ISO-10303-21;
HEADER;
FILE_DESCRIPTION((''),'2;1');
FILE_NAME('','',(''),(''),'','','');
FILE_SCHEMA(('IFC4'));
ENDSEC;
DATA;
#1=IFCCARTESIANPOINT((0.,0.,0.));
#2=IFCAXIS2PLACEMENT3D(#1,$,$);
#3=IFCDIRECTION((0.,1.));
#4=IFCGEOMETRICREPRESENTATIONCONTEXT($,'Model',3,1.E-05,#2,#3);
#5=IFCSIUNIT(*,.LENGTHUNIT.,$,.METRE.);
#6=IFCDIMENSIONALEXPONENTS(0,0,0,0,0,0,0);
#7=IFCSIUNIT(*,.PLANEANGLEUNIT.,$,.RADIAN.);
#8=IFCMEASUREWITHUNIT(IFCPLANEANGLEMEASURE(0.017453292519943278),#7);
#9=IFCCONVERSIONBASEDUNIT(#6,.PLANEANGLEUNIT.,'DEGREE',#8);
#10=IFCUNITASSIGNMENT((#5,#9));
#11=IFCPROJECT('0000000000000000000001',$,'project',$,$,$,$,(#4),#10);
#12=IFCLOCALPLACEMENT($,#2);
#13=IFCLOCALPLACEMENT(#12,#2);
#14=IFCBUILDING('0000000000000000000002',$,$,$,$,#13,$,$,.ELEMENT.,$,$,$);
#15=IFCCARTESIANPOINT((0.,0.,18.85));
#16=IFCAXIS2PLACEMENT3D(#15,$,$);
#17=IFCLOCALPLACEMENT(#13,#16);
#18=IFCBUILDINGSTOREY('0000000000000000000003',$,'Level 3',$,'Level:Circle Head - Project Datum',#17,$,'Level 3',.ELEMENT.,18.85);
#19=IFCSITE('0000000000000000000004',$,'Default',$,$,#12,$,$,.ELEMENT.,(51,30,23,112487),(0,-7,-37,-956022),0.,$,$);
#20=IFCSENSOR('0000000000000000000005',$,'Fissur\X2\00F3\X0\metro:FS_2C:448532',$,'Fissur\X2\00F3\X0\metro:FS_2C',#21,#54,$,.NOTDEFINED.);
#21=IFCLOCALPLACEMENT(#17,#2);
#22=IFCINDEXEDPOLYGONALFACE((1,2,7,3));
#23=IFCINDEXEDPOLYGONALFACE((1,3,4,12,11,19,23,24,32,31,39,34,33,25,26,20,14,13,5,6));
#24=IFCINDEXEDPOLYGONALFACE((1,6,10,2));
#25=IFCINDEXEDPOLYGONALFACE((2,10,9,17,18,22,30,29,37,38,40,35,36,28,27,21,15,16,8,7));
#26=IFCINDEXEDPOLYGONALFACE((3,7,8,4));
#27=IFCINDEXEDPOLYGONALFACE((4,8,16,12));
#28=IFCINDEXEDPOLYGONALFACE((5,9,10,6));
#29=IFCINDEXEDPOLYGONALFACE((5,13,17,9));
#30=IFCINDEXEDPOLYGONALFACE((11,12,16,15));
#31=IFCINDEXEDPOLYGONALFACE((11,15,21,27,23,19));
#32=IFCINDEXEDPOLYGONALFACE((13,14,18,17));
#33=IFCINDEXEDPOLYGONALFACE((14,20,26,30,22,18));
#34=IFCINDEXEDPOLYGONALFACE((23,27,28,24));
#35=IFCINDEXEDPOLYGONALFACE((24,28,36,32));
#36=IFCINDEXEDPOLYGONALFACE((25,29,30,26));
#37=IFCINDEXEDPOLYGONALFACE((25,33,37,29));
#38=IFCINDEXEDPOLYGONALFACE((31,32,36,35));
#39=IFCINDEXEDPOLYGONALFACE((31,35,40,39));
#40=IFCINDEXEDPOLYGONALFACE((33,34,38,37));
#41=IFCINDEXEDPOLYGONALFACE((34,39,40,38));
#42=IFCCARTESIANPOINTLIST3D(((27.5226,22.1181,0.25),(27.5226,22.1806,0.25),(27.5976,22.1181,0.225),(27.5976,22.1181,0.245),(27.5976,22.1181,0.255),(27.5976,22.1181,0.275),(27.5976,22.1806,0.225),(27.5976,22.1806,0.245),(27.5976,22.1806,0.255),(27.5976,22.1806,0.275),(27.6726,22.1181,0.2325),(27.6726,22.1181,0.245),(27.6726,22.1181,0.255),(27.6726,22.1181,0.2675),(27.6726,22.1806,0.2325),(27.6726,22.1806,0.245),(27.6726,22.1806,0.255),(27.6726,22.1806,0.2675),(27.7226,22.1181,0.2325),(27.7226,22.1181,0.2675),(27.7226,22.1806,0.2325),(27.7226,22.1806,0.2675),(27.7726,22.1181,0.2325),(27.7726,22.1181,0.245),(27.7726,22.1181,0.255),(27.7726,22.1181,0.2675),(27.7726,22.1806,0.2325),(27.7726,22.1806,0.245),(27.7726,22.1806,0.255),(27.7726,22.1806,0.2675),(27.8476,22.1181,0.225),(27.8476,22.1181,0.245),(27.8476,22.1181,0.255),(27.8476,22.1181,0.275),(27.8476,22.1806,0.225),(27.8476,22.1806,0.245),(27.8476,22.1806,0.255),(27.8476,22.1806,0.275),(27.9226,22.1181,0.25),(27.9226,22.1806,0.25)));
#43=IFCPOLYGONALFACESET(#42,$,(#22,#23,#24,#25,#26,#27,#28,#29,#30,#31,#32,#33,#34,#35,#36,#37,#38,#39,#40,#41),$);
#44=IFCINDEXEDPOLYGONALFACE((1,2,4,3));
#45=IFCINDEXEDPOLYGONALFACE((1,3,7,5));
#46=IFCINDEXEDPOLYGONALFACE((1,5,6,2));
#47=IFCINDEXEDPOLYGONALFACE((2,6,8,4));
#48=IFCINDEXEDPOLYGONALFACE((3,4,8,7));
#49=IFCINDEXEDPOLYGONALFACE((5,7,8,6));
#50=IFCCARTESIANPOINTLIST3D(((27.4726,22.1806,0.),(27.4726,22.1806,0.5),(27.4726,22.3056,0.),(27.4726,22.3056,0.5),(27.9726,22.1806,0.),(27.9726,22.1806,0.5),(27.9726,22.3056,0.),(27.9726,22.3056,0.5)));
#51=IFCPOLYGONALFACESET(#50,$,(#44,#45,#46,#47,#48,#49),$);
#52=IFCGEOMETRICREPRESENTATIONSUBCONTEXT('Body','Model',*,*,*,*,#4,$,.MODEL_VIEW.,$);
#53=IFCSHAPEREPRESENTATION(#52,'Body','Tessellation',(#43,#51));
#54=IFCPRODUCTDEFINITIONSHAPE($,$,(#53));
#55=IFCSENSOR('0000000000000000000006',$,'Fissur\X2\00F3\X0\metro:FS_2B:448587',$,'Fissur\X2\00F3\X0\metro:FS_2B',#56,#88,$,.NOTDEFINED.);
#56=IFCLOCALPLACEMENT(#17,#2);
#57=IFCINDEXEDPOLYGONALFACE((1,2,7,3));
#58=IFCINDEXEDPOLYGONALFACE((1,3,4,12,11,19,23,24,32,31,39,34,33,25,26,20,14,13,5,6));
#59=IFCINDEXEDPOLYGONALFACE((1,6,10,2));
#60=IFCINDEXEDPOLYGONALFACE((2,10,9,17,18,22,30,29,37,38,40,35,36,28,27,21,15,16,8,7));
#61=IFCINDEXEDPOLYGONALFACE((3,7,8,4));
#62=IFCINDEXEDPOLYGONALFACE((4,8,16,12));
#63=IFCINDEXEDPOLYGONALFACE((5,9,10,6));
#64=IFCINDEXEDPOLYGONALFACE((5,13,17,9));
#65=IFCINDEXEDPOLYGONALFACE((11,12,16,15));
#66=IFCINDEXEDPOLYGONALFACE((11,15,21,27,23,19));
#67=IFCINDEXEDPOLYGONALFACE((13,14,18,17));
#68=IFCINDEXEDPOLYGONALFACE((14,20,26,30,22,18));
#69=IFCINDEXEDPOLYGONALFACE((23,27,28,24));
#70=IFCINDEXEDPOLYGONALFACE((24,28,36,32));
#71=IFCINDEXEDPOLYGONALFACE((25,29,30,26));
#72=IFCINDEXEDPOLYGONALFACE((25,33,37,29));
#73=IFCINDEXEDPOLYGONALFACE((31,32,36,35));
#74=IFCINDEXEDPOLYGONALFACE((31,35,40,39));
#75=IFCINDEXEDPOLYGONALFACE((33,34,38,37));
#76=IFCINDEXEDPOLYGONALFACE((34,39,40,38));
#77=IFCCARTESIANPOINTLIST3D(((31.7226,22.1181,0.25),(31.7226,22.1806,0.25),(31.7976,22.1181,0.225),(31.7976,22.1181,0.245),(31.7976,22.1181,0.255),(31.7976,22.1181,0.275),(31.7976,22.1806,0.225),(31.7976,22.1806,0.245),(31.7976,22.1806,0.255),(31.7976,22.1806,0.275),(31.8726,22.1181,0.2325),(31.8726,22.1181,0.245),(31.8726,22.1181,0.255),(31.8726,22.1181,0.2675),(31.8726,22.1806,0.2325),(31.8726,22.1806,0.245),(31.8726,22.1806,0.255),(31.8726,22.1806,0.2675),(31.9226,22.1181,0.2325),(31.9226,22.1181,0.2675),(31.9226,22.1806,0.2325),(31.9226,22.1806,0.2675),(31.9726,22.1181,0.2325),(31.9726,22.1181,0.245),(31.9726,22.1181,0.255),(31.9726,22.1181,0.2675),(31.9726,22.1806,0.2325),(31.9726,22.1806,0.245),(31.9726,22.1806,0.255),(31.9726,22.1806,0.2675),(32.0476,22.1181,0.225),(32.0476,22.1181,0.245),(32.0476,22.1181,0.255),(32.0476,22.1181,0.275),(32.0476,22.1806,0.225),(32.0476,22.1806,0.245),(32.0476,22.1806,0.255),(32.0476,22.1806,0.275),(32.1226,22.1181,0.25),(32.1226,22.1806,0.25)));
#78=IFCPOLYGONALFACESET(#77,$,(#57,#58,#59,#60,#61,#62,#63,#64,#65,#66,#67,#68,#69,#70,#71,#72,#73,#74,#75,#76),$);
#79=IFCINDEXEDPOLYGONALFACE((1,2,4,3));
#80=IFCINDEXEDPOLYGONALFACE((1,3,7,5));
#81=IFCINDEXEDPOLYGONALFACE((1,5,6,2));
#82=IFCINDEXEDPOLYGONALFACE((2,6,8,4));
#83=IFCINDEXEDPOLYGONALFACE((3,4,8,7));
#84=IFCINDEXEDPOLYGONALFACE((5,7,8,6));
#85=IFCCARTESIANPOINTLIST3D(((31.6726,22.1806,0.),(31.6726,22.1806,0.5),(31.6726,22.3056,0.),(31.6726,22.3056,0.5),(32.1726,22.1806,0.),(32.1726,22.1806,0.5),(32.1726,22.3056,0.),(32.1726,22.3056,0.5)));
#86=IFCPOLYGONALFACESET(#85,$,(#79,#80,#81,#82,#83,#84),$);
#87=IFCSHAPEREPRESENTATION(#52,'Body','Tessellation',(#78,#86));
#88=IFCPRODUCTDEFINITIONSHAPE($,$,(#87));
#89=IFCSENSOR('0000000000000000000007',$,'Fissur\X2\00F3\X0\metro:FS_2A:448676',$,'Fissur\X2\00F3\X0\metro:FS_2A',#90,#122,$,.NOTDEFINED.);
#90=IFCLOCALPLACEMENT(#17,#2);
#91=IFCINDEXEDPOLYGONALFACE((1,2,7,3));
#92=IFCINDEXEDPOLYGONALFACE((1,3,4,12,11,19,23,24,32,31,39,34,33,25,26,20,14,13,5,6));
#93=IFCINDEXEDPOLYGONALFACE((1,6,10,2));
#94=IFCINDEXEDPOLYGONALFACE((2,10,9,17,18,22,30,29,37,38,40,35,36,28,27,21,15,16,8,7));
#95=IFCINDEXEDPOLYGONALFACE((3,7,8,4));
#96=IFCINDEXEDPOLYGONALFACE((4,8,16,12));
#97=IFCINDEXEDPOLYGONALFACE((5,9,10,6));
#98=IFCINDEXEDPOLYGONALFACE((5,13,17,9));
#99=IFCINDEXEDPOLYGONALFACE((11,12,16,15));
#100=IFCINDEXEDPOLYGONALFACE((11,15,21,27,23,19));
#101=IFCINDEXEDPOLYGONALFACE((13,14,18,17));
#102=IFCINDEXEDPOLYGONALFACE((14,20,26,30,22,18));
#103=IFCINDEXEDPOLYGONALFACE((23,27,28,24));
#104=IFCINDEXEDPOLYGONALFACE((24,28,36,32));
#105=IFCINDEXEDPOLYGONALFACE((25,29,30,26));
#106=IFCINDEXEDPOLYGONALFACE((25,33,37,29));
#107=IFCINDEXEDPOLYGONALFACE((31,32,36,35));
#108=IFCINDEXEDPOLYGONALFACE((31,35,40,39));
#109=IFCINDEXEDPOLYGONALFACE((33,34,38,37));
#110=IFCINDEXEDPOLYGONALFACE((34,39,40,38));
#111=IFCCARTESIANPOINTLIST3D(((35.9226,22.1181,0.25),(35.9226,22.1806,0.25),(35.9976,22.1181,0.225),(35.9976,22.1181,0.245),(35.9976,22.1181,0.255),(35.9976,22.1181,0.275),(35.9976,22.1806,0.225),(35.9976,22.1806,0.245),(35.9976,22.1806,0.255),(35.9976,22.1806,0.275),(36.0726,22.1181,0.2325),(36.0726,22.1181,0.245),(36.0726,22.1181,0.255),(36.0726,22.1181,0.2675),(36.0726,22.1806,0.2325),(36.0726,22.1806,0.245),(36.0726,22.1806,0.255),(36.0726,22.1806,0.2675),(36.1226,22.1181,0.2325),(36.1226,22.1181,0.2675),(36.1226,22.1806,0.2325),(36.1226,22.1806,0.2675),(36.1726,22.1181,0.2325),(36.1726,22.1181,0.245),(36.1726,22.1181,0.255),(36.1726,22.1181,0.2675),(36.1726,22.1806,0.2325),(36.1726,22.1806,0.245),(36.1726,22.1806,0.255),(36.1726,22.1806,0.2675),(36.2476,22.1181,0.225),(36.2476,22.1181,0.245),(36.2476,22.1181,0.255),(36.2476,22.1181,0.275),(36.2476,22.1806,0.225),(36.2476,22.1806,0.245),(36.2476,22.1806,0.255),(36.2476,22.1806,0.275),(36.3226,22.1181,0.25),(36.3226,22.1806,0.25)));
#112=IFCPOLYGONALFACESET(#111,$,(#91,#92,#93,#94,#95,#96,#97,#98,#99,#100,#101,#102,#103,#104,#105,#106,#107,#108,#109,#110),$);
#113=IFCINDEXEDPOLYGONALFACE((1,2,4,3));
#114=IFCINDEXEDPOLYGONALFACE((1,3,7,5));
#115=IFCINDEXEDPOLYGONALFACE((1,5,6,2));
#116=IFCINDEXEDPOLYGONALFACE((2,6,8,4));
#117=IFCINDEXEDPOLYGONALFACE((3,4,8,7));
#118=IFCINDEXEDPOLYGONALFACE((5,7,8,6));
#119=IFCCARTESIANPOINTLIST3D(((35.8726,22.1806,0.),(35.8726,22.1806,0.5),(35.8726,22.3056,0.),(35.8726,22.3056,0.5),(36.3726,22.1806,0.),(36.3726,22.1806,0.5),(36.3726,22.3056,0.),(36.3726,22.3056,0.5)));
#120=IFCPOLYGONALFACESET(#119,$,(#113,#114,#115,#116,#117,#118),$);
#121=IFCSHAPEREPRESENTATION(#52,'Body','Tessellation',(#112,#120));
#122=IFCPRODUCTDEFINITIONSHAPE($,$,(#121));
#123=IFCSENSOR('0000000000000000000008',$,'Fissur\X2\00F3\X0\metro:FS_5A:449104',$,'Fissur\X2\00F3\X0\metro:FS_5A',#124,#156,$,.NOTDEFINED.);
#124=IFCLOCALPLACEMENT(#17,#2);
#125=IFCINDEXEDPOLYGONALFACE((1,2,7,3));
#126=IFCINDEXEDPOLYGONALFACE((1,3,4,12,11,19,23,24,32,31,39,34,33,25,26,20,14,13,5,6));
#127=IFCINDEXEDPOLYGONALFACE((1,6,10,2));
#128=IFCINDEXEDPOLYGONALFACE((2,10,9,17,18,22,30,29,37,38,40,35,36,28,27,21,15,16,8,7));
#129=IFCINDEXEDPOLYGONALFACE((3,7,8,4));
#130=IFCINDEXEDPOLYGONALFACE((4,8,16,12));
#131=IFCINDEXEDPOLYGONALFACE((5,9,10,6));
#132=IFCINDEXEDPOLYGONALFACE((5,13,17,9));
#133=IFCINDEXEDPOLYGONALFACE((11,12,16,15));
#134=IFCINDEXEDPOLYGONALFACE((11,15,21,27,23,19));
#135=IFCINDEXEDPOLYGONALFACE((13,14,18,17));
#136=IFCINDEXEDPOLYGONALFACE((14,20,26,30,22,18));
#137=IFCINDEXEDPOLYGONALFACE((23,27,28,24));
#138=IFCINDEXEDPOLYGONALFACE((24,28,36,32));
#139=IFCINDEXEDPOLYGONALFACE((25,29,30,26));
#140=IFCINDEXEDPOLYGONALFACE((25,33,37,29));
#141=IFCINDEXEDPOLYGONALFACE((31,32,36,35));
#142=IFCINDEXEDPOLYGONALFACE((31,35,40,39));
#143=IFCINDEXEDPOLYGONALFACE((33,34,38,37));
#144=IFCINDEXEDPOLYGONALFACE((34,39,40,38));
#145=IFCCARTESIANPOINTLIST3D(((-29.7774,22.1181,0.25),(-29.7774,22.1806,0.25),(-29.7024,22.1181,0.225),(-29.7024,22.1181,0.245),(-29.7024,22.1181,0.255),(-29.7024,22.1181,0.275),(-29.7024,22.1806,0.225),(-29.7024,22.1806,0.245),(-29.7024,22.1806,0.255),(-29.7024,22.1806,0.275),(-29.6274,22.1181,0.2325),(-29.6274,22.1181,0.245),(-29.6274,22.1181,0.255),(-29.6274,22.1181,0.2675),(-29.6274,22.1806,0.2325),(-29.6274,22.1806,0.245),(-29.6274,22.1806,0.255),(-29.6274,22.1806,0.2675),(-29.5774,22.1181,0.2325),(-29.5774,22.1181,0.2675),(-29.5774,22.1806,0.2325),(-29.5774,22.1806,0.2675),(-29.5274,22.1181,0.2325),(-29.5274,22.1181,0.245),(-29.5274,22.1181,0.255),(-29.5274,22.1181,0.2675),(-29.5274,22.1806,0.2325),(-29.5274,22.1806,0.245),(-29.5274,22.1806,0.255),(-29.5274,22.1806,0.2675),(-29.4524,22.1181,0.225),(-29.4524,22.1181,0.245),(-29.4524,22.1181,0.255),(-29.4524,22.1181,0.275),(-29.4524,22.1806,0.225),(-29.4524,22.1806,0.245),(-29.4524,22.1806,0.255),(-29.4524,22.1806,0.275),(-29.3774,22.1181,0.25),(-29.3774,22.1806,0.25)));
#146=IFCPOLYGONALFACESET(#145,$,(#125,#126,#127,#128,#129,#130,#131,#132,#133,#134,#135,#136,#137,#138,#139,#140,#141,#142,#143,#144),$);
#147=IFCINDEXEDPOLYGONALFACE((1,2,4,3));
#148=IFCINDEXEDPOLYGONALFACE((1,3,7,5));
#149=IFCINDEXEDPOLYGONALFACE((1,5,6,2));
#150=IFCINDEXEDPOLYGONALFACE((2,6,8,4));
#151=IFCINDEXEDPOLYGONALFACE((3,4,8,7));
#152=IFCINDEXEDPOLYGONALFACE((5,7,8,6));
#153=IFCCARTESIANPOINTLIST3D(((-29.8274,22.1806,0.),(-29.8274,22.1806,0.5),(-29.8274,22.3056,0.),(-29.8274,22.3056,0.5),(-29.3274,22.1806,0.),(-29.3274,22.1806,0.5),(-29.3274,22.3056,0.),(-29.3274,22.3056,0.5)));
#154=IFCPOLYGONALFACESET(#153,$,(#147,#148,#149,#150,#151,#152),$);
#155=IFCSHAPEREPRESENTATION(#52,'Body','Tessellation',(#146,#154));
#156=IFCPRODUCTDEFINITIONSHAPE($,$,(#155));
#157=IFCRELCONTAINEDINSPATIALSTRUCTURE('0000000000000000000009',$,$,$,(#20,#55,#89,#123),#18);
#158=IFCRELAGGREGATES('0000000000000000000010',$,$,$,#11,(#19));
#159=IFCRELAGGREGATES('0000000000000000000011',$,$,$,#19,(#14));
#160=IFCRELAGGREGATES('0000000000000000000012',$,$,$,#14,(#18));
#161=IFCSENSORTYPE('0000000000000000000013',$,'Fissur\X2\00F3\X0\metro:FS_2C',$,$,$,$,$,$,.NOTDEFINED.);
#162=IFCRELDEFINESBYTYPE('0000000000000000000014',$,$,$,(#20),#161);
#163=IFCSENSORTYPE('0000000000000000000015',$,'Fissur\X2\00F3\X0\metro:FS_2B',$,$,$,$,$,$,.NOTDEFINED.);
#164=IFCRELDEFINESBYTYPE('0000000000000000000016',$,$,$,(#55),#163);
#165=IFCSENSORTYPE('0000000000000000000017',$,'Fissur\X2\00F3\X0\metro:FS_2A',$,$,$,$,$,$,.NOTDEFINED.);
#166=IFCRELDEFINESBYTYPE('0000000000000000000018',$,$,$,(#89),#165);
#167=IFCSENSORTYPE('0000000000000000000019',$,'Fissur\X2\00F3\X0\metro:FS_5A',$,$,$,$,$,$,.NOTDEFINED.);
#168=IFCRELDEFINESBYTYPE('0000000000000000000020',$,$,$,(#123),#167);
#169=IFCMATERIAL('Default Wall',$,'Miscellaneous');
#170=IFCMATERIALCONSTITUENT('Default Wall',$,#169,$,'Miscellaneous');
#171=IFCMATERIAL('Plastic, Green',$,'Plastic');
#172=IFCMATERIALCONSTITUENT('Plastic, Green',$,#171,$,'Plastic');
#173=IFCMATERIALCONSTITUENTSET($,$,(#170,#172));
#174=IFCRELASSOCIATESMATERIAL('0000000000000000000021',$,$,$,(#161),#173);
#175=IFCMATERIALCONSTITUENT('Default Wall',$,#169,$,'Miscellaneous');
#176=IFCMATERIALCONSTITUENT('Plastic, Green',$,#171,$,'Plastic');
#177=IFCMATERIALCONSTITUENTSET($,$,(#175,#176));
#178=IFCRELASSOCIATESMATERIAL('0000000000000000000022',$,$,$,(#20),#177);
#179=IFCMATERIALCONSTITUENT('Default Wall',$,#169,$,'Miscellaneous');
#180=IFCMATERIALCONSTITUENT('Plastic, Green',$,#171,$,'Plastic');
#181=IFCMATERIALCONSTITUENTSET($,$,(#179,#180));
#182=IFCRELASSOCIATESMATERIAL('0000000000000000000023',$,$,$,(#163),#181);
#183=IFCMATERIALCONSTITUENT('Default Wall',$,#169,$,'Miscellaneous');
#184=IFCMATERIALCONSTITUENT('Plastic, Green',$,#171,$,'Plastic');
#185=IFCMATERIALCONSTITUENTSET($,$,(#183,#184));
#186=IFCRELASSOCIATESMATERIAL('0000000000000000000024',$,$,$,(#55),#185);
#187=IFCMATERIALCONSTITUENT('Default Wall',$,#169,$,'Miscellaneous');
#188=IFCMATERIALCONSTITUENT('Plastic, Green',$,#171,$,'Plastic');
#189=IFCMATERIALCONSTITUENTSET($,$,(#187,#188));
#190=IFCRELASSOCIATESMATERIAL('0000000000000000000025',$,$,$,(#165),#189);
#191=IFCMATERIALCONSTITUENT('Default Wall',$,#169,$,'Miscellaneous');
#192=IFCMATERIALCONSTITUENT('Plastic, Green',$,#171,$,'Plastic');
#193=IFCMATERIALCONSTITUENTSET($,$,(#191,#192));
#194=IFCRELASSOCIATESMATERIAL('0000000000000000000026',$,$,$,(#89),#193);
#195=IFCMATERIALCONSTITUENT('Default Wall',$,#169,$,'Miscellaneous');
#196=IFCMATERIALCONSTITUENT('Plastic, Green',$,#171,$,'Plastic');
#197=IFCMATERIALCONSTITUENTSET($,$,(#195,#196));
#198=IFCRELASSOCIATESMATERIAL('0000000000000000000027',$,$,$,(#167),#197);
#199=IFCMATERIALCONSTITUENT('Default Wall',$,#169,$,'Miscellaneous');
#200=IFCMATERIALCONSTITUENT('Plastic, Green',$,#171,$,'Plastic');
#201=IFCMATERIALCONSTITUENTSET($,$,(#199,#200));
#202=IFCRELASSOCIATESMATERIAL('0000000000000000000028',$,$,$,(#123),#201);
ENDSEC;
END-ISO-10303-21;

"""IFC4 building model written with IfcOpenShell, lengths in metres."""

from ifc_helpers import new_model, entity, si_unit, converted_unit, direction, frame, origin, place, context, subcontext, project, spatial, indexed_curve, outline, extrude, source, transform, mapped, material, constituent, constituent_set, type_object, type_shapes, element, save


model = new_model("IFC4")

# Units and contexts
model_context = context("Model", 3, precision=1e-05, world=origin(), true_north=direction((0.0, 1.0)))
body_context = subcontext(model_context, "Body", "Model", "MODEL_VIEW")
ifc_project = project(units=[si_unit("LENGTHUNIT", "METRE"), converted_unit("PLANEANGLEUNIT", "DEGREE", entity("IfcPlaneAngleMeasure", 0.017453292519943278), si_unit("PLANEANGLEUNIT", "RADIAN"), dimensions=[0, 0, 0, 0, 0, 0, 0])], contexts=[model_context])

# Site, building, storey
site_placement = place(None, origin())
site = spatial("IfcSite", under=ifc_project, at=site_placement, Name="Default", CompositionType="ELEMENT", RefLatitude=(51, 30, 23, 112487), RefLongitude=(0, -7, -37, -956022), RefElevation=0.0)
building_placement = place(site_placement, origin())
building = spatial("IfcBuilding", under=site, at=building_placement, CompositionType="ELEMENT")
storey_placement = place(building_placement, frame((0.0, 0.0, 18.85)))
storey = spatial("IfcBuildingStorey", under=building, at=storey_placement, Name="Level 3", ObjectType="Level:Circle Head - Project Datum", LongName="Level 3", CompositionType="ELEMENT", Elevation=18.85)

# Sensors
ifc_material_1 = material(Name="Default Wall", Category="Miscellaneous")
ifc_constituent_1 = constituent(ifc_material_1, Name="Default Wall", Category="Miscellaneous")
ifc_material_2 = material(Name="Plastic, Green", Category="Plastic")
ifc_constituent_2 = constituent(ifc_material_2, Name="Plastic, Green", Category="Plastic")
ifc_constituent_set_1 = constituent_set(constituents=[ifc_constituent_1, ifc_constituent_2])
ifc_constituent_3 = constituent(ifc_material_1, Name="Default Wall", Category="Miscellaneous")
ifc_constituent_4 = constituent(ifc_material_2, Name="Plastic, Green", Category="Plastic")
ifc_constituent_set_2 = constituent_set(constituents=[ifc_constituent_3, ifc_constituent_4])
sensor_type_1 = type_object("IfcSensorType", Name="Fissurómetro:FS_2C", PredefinedType="NOTDEFINED", material=ifc_constituent_set_2)
shared_shape_1 = source(origin(), body_context, "Body", "SweptSolid", [
    extrude(outline(indexed_curve([(-0.025, -0.125), (0.0, -0.2), (0.025, -0.125), (0.005, -0.125), (0.005, -0.05), (0.0175, -0.05), (0.0175, 0.0), (0.0175, 0.05), (0.005, 0.05), (0.005, 0.125), (0.025, 0.125), (0.0, 0.2), (-0.025, 0.125), (-0.005, 0.125), (-0.005, 0.05), (-0.0175, 0.05), (-0.0175, 0.0), (-0.0175, -0.05), (-0.005, -0.05), (-0.005, -0.125), (-0.025, -0.125)], self_intersect=False)), frame((0.0, -0.125, 0.25), z_axis=(0.0, -1.0, 0.0), x_axis=(0.0, 0.0, -1.0)), (0.0, 0.0, -1.0), 0.0625),
    extrude(outline(indexed_curve([(-0.25, -0.0625), (0.25, -0.0625), (0.25, 0.0625), (-0.25, 0.0625), (-0.25, -0.0625)], self_intersect=False)), frame((0.0, 0.0, 0.0), z_axis=(0.0, 0.0, 1.0), x_axis=(-1.0, 0.0, 0.0)), (0.0, 0.0, 1.0), 0.5),
])
type_shapes(sensor_type_1, [shared_shape_1])
sensor_1_placement = place(storey_placement, frame((27.7226, 22.2431, 0.0)))
element("IfcSensor", 1, at=sensor_1_placement, inside=storey, type_object=sensor_type_1, material=ifc_constituent_set_1, Name="Fissurómetro:FS_2C:448532", ObjectType="Fissurómetro:FS_2C", PredefinedType="NOTDEFINED", context=body_context, shape_type="MappedRepresentation", body=[
    mapped(shared_shape_1, transform((0.0, 0.0, 0.0), scale=1.0)),
])
ifc_constituent_5 = constituent(ifc_material_1, Name="Default Wall", Category="Miscellaneous")
ifc_constituent_6 = constituent(ifc_material_2, Name="Plastic, Green", Category="Plastic")
ifc_constituent_set_3 = constituent_set(constituents=[ifc_constituent_5, ifc_constituent_6])
ifc_constituent_7 = constituent(ifc_material_1, Name="Default Wall", Category="Miscellaneous")
ifc_constituent_8 = constituent(ifc_material_2, Name="Plastic, Green", Category="Plastic")
ifc_constituent_set_4 = constituent_set(constituents=[ifc_constituent_7, ifc_constituent_8])
sensor_type_2 = type_object("IfcSensorType", Name="Fissurómetro:FS_2B", PredefinedType="NOTDEFINED", material=ifc_constituent_set_4)
shared_shape_2 = source(origin(), body_context, "Body", "SweptSolid", [
    extrude(outline(indexed_curve([(-0.025, -0.125), (0.0, -0.2), (0.025, -0.125), (0.005, -0.125), (0.005, -0.05), (0.0175, -0.05), (0.0175, 0.0), (0.0175, 0.05), (0.005, 0.05), (0.005, 0.125), (0.025, 0.125), (0.0, 0.2), (-0.025, 0.125), (-0.005, 0.125), (-0.005, 0.05), (-0.0175, 0.05), (-0.0175, 0.0), (-0.0175, -0.05), (-0.005, -0.05), (-0.005, -0.125), (-0.025, -0.125)], self_intersect=False)), frame((0.0, -0.125, 0.25), z_axis=(0.0, -1.0, 0.0), x_axis=(0.0, 0.0, -1.0)), (0.0, 0.0, -1.0), 0.0625),
    extrude(outline(indexed_curve([(-0.25, -0.0625), (0.25, -0.0625), (0.25, 0.0625), (-0.25, 0.0625), (-0.25, -0.0625)], self_intersect=False)), frame((0.0, 0.0, 0.0), z_axis=(0.0, 0.0, 1.0), x_axis=(-1.0, 0.0, 0.0)), (0.0, 0.0, 1.0), 0.5),
])
type_shapes(sensor_type_2, [shared_shape_2])
sensor_2_placement = place(storey_placement, frame((31.9226, 22.2431, 0.0)))
element("IfcSensor", 2, at=sensor_2_placement, inside=storey, type_object=sensor_type_2, material=ifc_constituent_set_3, Name="Fissurómetro:FS_2B:448587", ObjectType="Fissurómetro:FS_2B", PredefinedType="NOTDEFINED", context=body_context, shape_type="MappedRepresentation", body=[
    mapped(shared_shape_2, transform((0.0, 0.0, 0.0), scale=1.0)),
])
ifc_constituent_9 = constituent(ifc_material_1, Name="Default Wall", Category="Miscellaneous")
ifc_constituent_10 = constituent(ifc_material_2, Name="Plastic, Green", Category="Plastic")
ifc_constituent_set_5 = constituent_set(constituents=[ifc_constituent_9, ifc_constituent_10])
ifc_constituent_11 = constituent(ifc_material_1, Name="Default Wall", Category="Miscellaneous")
ifc_constituent_12 = constituent(ifc_material_2, Name="Plastic, Green", Category="Plastic")
ifc_constituent_set_6 = constituent_set(constituents=[ifc_constituent_11, ifc_constituent_12])
sensor_type_3 = type_object("IfcSensorType", Name="Fissurómetro:FS_2A", PredefinedType="NOTDEFINED", material=ifc_constituent_set_6)
shared_shape_3 = source(origin(), body_context, "Body", "SweptSolid", [
    extrude(outline(indexed_curve([(-0.025, -0.125), (0.0, -0.2), (0.025, -0.125), (0.005, -0.125), (0.005, -0.05), (0.0175, -0.05), (0.0175, 0.0), (0.0175, 0.05), (0.005, 0.05), (0.005, 0.125), (0.025, 0.125), (0.0, 0.2), (-0.025, 0.125), (-0.005, 0.125), (-0.005, 0.05), (-0.0175, 0.05), (-0.0175, 0.0), (-0.0175, -0.05), (-0.005, -0.05), (-0.005, -0.125), (-0.025, -0.125)], self_intersect=False)), frame((0.0, -0.125, 0.25), z_axis=(0.0, -1.0, 0.0), x_axis=(0.0, 0.0, -1.0)), (0.0, 0.0, -1.0), 0.0625),
    extrude(outline(indexed_curve([(-0.25, -0.0625), (0.25, -0.0625), (0.25, 0.0625), (-0.25, 0.0625), (-0.25, -0.0625)], self_intersect=False)), frame((0.0, 0.0, 0.0), z_axis=(0.0, 0.0, 1.0), x_axis=(-1.0, 0.0, 0.0)), (0.0, 0.0, 1.0), 0.5),
])
type_shapes(sensor_type_3, [shared_shape_3])
sensor_3_placement = place(storey_placement, frame((36.1226, 22.2431, 0.0)))
element("IfcSensor", 3, at=sensor_3_placement, inside=storey, type_object=sensor_type_3, material=ifc_constituent_set_5, Name="Fissurómetro:FS_2A:448676", ObjectType="Fissurómetro:FS_2A", PredefinedType="NOTDEFINED", context=body_context, shape_type="MappedRepresentation", body=[
    mapped(shared_shape_3, transform((0.0, 0.0, 0.0), scale=1.0)),
])
ifc_constituent_13 = constituent(ifc_material_1, Name="Default Wall", Category="Miscellaneous")
ifc_constituent_14 = constituent(ifc_material_2, Name="Plastic, Green", Category="Plastic")
ifc_constituent_set_7 = constituent_set(constituents=[ifc_constituent_13, ifc_constituent_14])
ifc_constituent_15 = constituent(ifc_material_1, Name="Default Wall", Category="Miscellaneous")
ifc_constituent_16 = constituent(ifc_material_2, Name="Plastic, Green", Category="Plastic")
ifc_constituent_set_8 = constituent_set(constituents=[ifc_constituent_15, ifc_constituent_16])
sensor_type_4 = type_object("IfcSensorType", Name="Fissurómetro:FS_5A", PredefinedType="NOTDEFINED", material=ifc_constituent_set_8)
shared_shape_4 = source(origin(), body_context, "Body", "SweptSolid", [
    extrude(outline(indexed_curve([(-0.025, -0.125), (0.0, -0.2), (0.025, -0.125), (0.005, -0.125), (0.005, -0.05), (0.0175, -0.05), (0.0175, 0.0), (0.0175, 0.05), (0.005, 0.05), (0.005, 0.125), (0.025, 0.125), (0.0, 0.2), (-0.025, 0.125), (-0.005, 0.125), (-0.005, 0.05), (-0.0175, 0.05), (-0.0175, 0.0), (-0.0175, -0.05), (-0.005, -0.05), (-0.005, -0.125), (-0.025, -0.125)], self_intersect=False)), frame((0.0, -0.125, 0.25), z_axis=(0.0, -1.0, 0.0), x_axis=(0.0, 0.0, -1.0)), (0.0, 0.0, -1.0), 0.0625),
    extrude(outline(indexed_curve([(-0.25, -0.0625), (0.25, -0.0625), (0.25, 0.0625), (-0.25, 0.0625), (-0.25, -0.0625)], self_intersect=False)), frame((0.0, 0.0, 0.0), z_axis=(0.0, 0.0, 1.0), x_axis=(-1.0, 0.0, 0.0)), (0.0, 0.0, 1.0), 0.5),
])
type_shapes(sensor_type_4, [shared_shape_4])
sensor_4_placement = place(storey_placement, frame((-29.5774, 22.2431, 0.0)))
element("IfcSensor", 4, at=sensor_4_placement, inside=storey, type_object=sensor_type_4, material=ifc_constituent_set_7, Name="Fissurómetro:FS_5A:449104", ObjectType="Fissurómetro:FS_5A", PredefinedType="NOTDEFINED", context=body_context, shape_type="MappedRepresentation", body=[
    mapped(shared_shape_4, transform((0.0, 0.0, 0.0), scale=1.0)),
])

save(model, "model.ifc")
